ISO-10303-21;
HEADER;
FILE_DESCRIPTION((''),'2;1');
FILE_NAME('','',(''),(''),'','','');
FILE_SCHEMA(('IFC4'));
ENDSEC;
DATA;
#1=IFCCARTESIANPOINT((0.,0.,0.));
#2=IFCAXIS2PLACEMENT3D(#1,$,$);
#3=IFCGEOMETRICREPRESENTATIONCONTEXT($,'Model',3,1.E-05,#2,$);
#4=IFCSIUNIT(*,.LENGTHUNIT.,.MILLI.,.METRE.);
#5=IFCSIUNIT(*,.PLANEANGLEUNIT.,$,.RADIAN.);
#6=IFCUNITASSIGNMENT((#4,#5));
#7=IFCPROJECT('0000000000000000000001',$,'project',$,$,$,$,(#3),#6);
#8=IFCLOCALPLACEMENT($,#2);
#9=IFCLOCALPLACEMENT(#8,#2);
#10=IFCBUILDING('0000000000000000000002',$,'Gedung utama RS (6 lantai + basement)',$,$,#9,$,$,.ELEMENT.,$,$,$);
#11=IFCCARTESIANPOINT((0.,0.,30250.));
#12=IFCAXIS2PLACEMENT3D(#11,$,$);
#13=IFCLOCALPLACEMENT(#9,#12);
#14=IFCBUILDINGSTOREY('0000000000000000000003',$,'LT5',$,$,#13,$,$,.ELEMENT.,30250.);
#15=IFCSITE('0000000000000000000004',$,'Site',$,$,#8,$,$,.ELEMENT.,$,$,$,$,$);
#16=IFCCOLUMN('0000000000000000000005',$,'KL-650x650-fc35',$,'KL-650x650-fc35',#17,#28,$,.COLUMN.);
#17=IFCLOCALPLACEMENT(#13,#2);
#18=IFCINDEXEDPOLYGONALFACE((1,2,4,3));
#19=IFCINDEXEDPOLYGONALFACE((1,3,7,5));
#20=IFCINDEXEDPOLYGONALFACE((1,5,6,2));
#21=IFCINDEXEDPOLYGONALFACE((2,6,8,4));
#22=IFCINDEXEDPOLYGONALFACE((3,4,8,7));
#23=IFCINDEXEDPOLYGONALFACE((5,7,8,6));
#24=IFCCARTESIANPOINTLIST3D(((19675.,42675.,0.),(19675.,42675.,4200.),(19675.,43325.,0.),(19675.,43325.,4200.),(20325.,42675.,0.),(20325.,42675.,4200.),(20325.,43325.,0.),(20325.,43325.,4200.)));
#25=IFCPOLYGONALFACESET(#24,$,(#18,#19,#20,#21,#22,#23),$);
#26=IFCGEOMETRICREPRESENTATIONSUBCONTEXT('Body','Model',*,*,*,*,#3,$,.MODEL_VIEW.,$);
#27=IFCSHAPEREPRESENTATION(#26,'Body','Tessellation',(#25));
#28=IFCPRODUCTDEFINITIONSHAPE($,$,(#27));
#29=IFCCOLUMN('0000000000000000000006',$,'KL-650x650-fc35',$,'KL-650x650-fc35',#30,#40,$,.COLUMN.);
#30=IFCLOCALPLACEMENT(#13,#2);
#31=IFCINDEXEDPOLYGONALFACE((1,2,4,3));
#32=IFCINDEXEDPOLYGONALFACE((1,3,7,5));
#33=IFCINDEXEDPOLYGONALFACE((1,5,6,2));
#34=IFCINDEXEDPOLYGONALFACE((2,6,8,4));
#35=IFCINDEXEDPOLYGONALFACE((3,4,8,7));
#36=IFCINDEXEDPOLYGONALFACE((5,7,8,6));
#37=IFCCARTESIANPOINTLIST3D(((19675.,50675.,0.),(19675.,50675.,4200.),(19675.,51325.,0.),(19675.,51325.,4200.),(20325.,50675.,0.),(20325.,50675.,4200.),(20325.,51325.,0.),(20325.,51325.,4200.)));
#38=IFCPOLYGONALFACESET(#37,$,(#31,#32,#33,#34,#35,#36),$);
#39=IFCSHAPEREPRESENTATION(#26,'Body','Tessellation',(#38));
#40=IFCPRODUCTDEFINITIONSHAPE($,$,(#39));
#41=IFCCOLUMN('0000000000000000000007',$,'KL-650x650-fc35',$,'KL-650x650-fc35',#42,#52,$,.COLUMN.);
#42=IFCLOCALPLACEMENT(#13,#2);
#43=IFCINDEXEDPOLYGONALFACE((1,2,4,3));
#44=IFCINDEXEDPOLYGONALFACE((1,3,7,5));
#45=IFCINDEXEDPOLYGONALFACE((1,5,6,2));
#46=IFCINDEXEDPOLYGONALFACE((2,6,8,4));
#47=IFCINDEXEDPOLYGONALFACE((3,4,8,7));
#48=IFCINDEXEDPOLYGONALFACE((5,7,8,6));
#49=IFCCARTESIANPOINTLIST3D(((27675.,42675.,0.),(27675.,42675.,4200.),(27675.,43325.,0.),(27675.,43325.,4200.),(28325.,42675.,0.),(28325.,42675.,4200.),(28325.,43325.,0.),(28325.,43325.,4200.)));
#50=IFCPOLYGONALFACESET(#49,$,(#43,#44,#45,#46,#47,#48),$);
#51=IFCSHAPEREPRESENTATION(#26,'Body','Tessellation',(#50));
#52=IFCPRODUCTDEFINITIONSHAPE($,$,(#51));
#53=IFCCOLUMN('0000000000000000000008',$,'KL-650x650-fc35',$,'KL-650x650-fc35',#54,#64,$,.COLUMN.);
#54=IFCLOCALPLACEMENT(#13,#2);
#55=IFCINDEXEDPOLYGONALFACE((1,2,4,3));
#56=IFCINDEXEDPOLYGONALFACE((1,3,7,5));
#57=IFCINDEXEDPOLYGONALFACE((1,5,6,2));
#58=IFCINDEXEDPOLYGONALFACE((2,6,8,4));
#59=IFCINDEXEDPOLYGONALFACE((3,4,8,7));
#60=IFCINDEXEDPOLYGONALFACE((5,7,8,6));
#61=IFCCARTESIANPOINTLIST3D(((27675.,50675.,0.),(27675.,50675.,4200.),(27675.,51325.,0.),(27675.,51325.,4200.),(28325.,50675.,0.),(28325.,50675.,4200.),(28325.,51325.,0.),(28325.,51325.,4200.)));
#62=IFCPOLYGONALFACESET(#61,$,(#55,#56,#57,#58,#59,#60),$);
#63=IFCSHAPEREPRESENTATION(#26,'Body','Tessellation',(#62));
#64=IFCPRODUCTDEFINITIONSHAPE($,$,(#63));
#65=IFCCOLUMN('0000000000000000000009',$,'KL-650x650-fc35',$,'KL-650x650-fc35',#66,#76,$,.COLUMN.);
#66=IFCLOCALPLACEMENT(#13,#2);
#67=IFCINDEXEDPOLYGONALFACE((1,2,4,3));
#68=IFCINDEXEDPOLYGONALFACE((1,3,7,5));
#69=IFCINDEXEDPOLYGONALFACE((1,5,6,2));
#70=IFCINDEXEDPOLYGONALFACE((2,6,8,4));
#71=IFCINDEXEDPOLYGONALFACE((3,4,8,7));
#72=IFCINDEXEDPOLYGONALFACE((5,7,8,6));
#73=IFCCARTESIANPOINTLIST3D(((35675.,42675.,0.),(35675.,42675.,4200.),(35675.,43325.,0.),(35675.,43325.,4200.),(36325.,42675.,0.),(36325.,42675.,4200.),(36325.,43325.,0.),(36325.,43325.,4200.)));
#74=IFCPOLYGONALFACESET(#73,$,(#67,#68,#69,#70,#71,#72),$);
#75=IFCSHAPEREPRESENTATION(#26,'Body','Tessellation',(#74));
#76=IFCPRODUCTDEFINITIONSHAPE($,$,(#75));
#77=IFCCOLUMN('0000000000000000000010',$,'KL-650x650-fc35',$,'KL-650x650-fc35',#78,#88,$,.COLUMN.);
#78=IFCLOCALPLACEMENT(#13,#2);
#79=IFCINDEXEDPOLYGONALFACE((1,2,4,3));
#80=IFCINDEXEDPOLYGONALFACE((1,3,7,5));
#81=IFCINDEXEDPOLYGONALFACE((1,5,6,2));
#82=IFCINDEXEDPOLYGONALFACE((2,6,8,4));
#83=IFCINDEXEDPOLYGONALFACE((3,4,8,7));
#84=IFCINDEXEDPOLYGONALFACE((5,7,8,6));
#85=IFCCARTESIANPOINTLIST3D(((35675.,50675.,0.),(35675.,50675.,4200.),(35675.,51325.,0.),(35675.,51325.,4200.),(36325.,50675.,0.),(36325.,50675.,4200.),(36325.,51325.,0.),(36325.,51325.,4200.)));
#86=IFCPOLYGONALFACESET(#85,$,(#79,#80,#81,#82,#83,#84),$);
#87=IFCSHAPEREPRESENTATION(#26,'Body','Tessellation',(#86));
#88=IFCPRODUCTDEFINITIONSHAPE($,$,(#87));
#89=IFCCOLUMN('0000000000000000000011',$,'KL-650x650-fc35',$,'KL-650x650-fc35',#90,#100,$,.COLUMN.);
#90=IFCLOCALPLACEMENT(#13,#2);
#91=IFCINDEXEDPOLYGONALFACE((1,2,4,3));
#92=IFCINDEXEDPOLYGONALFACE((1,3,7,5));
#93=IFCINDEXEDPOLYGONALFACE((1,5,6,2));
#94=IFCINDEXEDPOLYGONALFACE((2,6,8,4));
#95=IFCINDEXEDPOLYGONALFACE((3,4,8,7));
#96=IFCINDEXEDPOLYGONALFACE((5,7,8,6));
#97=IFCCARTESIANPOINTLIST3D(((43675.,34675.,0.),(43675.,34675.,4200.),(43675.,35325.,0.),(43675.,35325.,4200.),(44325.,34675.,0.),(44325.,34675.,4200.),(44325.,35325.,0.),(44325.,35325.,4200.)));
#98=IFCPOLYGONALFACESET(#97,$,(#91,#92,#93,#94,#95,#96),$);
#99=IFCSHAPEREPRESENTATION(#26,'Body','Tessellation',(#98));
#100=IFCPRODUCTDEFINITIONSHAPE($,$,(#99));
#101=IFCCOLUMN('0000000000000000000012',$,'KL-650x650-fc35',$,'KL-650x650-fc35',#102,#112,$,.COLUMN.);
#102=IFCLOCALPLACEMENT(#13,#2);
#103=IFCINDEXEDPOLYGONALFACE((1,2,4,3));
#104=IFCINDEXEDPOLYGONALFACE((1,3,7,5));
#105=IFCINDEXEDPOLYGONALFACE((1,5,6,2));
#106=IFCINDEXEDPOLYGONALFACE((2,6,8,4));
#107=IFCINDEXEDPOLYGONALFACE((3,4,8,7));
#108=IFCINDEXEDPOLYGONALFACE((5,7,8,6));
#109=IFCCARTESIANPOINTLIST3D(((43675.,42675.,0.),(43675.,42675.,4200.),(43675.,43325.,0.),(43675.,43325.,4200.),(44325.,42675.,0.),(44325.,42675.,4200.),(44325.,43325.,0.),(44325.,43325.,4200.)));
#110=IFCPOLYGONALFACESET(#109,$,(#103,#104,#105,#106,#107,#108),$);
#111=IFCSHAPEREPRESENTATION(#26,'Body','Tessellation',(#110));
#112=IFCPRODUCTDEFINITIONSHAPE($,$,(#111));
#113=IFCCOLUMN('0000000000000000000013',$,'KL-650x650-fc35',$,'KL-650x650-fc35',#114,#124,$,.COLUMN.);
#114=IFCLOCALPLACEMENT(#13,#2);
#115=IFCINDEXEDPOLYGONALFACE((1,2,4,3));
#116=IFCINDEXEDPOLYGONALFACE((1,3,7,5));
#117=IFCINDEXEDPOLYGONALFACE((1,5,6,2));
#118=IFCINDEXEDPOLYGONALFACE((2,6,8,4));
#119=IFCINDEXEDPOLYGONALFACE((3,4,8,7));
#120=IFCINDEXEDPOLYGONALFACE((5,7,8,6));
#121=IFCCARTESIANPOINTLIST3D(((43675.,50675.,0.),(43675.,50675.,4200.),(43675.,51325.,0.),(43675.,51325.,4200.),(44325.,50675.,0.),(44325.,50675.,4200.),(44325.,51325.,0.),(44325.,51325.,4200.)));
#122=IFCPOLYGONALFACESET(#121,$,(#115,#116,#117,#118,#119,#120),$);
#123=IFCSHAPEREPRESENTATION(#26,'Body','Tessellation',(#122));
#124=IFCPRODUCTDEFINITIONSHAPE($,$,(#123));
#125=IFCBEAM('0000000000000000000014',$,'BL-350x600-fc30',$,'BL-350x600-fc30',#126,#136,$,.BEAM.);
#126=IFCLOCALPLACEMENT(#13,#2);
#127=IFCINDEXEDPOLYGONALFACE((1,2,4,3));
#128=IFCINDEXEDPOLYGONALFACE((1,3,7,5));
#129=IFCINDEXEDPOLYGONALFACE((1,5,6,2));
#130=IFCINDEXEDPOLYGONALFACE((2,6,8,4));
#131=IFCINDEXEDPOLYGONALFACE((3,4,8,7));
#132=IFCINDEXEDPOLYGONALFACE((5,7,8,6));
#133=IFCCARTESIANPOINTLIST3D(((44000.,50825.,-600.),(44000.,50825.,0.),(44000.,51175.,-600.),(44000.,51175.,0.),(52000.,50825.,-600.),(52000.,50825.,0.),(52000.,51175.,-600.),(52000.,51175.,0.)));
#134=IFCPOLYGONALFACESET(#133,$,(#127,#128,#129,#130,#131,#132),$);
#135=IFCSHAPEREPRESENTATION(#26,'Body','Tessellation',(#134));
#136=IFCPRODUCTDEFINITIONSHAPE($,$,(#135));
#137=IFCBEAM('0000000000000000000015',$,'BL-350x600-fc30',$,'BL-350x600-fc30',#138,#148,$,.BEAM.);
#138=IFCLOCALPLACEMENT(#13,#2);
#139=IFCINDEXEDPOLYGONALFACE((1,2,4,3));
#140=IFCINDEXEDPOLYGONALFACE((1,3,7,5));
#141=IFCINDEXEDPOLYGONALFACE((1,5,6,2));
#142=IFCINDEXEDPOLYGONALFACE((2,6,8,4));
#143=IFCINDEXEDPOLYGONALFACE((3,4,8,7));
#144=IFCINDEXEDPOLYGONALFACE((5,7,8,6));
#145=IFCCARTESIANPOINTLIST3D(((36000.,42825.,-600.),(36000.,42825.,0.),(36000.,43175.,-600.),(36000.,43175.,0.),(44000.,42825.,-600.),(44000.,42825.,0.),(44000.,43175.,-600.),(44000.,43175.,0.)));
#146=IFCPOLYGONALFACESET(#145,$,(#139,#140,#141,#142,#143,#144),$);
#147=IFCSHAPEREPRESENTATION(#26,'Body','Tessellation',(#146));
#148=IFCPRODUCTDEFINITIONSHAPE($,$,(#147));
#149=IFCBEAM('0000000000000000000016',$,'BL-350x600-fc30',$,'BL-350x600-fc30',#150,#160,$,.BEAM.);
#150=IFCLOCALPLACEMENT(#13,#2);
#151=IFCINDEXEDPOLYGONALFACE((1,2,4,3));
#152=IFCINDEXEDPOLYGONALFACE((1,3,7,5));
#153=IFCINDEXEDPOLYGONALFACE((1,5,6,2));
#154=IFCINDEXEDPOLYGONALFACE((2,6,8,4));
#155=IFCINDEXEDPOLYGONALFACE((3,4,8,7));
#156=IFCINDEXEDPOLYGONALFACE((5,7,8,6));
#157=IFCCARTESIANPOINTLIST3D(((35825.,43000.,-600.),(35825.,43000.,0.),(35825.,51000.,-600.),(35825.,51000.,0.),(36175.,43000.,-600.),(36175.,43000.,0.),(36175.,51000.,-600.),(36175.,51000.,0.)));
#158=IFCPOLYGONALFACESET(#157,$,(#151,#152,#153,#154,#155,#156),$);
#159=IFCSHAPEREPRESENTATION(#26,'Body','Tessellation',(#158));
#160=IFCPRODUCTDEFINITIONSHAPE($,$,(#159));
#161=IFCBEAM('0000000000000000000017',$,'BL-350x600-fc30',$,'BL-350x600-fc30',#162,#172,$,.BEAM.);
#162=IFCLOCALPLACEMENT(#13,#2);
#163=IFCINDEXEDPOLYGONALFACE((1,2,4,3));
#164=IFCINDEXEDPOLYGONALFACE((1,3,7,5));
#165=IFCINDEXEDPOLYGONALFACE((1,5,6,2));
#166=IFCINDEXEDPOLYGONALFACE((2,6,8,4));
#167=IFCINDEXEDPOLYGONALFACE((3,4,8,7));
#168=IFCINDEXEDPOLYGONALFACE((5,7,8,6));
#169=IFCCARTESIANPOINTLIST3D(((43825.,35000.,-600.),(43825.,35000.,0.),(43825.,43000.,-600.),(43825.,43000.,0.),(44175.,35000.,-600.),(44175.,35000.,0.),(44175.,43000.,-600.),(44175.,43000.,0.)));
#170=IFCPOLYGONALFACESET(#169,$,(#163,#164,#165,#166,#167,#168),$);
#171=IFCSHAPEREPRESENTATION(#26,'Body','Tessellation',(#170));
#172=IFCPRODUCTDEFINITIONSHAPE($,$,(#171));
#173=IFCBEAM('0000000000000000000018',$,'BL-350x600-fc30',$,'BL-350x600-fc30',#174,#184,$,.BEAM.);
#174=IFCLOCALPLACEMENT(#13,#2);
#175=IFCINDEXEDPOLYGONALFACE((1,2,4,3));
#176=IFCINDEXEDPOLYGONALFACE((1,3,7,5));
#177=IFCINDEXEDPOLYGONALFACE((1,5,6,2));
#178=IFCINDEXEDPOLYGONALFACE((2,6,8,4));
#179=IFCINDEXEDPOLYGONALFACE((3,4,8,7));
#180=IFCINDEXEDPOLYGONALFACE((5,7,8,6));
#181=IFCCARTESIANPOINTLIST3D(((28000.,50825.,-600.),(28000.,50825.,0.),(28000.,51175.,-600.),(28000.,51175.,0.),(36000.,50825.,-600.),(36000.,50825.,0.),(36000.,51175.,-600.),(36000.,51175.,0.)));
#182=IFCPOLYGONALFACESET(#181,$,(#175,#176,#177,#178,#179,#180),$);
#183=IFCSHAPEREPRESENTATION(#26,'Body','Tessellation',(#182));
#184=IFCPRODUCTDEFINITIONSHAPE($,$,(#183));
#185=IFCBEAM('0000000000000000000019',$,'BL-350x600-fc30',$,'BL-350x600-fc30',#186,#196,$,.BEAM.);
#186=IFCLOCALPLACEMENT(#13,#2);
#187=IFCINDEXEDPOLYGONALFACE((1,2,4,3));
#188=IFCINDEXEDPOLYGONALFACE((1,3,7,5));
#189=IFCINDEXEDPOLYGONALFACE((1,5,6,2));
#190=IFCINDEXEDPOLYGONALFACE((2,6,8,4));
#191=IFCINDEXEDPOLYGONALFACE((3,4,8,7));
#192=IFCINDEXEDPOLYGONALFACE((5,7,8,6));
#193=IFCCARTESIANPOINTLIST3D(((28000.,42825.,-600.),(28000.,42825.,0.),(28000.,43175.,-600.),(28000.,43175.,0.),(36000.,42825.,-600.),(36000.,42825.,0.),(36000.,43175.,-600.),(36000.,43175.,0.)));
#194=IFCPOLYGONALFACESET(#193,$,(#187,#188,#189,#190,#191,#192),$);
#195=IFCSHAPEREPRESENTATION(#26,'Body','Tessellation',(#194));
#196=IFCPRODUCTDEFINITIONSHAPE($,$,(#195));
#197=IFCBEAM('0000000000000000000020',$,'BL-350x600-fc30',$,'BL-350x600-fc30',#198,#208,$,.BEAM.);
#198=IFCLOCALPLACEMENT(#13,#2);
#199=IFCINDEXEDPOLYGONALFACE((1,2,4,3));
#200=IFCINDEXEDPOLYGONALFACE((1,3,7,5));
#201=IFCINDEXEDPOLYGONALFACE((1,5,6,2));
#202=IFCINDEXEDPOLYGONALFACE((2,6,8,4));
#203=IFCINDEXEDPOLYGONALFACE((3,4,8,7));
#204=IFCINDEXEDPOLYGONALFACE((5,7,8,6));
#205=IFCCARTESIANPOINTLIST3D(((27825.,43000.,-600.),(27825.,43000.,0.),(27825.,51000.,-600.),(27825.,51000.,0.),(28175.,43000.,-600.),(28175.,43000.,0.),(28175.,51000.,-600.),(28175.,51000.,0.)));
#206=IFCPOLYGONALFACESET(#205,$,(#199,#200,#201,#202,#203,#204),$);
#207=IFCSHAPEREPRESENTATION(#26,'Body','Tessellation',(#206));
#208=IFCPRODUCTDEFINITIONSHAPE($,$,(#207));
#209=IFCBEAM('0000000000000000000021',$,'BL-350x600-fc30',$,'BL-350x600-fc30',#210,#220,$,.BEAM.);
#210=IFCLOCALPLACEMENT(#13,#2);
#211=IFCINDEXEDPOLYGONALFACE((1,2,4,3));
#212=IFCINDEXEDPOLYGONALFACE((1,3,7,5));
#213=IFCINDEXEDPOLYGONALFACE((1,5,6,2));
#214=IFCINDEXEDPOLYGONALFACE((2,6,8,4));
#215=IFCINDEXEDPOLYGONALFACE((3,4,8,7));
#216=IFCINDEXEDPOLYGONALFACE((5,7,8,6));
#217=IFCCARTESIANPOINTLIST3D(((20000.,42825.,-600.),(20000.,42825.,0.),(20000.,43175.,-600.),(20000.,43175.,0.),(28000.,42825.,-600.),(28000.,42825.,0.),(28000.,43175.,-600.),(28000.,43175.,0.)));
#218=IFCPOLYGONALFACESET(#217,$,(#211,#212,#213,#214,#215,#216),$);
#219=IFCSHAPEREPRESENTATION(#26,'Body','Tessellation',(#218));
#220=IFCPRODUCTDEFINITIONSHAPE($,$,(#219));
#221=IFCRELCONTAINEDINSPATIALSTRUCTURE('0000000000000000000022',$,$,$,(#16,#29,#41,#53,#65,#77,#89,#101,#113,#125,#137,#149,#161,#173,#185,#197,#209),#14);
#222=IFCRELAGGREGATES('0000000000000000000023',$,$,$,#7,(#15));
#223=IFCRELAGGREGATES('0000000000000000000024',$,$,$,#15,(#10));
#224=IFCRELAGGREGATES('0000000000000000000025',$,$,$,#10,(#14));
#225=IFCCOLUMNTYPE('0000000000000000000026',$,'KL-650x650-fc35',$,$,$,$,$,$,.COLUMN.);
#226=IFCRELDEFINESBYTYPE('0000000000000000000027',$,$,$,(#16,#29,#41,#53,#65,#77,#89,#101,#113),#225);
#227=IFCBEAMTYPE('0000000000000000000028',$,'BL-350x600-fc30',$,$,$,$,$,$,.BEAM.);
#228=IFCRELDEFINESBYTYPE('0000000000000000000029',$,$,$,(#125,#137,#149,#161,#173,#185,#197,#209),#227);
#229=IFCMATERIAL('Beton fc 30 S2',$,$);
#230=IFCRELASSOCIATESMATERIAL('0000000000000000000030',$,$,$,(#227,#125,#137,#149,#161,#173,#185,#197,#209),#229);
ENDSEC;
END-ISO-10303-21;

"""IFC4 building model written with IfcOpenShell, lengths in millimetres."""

from ifc_helpers import new_model, si_unit, frame, origin, origin_2d, place, context, subcontext, project, spatial, rectangle, extrude, material, material_profile, profile_set, profile_usage, type_object, element, save


model = new_model("IFC4")

# Units and contexts
model_context = context("Model", 3, precision=1e-05, world=origin())
body_context = subcontext(model_context, "Body", "Model", "MODEL_VIEW")
ifc_project = project(units=[si_unit("LENGTHUNIT", "METRE", prefix="MILLI"), si_unit("PLANEANGLEUNIT", "RADIAN")], contexts=[model_context])

# Site, building, storey
site_placement = place(None, origin())
site = spatial("IfcSite", under=ifc_project, at=site_placement, Name="Site", CompositionType="ELEMENT")
building_placement = place(site_placement, origin())
building = spatial("IfcBuilding", under=site, at=building_placement, Name="Gedung utama RS (6 lantai + basement)", CompositionType="ELEMENT")
storey_placement = place(building_placement, frame((0.0, 0.0, 30250.0)))
storey = spatial("IfcBuildingStorey", under=building, at=storey_placement, Name="LT5", CompositionType="ELEMENT", Elevation=30250.0)

# Columns
ifc_material_profile_1 = material_profile(None, rectangle(XDim=650.0, YDim=650.0, at=origin_2d()), Name="KL-650x650-fc35")
ifc_profile_set_1 = profile_set([ifc_material_profile_1], Name="KL-650x650-fc35")
ifc_profile_usage_1 = profile_usage(ifc_profile_set_1, cardinal=5)
column_type = type_object("IfcColumnType", Name="KL-650x650-fc35", PredefinedType="COLUMN", material=ifc_profile_set_1)
for number, where, z_axis, x_axis, name in (
    (1, (20000.0, 43000.0, 0.0), (0.0, 0.0, 1.0), (1.0, 0.0, 0.0), "KL-650x650-fc35"),
    (2, (20000.0, 51000.0, 0.0), (0.0, 0.0, 1.0), (1.0, 0.0, 0.0), "KL-650x650-fc35"),
    (3, (28000.0, 43000.0, 0.0), (0.0, 0.0, 1.0), (1.0, 0.0, 0.0), "KL-650x650-fc35"),
    (4, (28000.0, 51000.0, 0.0), (0.0, 0.0, 1.0), (1.0, 0.0, 0.0), "KL-650x650-fc35"),
    (5, (36000.0, 43000.0, 0.0), (0.0, 0.0, 1.0), (1.0, 0.0, 0.0), "KL-650x650-fc35"),
    (6, (36000.0, 51000.0, 0.0), (0.0, 0.0, 1.0), (1.0, 0.0, 0.0), "KL-650x650-fc35"),
    (7, (44000.0, 35000.0, 0.0), (0.0, 0.0, 1.0), (1.0, 0.0, 0.0), "KL-650x650-fc35"),
    (8, (44000.0, 43000.0, 0.0), (0.0, 0.0, 1.0), (1.0, 0.0, 0.0), "KL-650x650-fc35"),
    (9, (44000.0, 51000.0, 0.0), (0.0, 0.0, 1.0), (1.0, 0.0, 0.0), "KL-650x650-fc35"),
):
    element("IfcColumn", number, at=place(storey_placement, frame(where, z_axis=z_axis, x_axis=x_axis)), inside=storey, type_object=column_type, material=ifc_profile_usage_1, Name=name, ObjectType="KL-650x650-fc35", PredefinedType="COLUMN", context=body_context, shape_type="SweptSolid", body=[
        extrude(rectangle(XDim=650.0, YDim=650.0, at=origin_2d()), origin(), (0.0, 0.0, 1.0), 4200.0),
    ])

# Beams
ifc_material_1 = material(Name="Beton fc 30 S2")
ifc_material_profile_2 = material_profile(ifc_material_1, rectangle(XDim=350.0, YDim=600.0, at=origin_2d()), Name="BL-350x600-fc30")
ifc_profile_set_2 = profile_set([ifc_material_profile_2], Name="BL-350x600-fc30")
ifc_profile_usage_2 = profile_usage(ifc_profile_set_2, cardinal=8)
beam_type = type_object("IfcBeamType", Name="BL-350x600-fc30", PredefinedType="BEAM", material=ifc_profile_set_2)
for number, where, name in (
    (10, (44000.0, 51000.0, -300.0), "BL-350x600-fc30"),
    (11, (36000.0, 43000.0, -300.0), "BL-350x600-fc30"),
):
    element("IfcBeam", number, at=place(storey_placement, frame(where)), inside=storey, type_object=beam_type, material=ifc_profile_usage_2, Name=name, ObjectType="BL-350x600-fc30", PredefinedType="BEAM", context=body_context, shape_type="SweptSolid", body=[
        extrude(rectangle(XDim=350.0, YDim=600.0, at=origin_2d()), frame((0.0, 0.0, 0.0), z_axis=(1.0, 0.0, 0.0), x_axis=(0.0, 1.0, 0.0)), (0.0, 0.0, 1.0), 8000.0),
    ])
for number, where, name in (
    (12, (36000.0, 43000.0, -300.0), "BL-350x600-fc30"),
    (13, (44000.0, 35000.0, -300.0), "BL-350x600-fc30"),
):
    element("IfcBeam", number, at=place(storey_placement, frame(where)), inside=storey, type_object=beam_type, material=ifc_profile_usage_2, Name=name, ObjectType="BL-350x600-fc30", PredefinedType="BEAM", context=body_context, shape_type="SweptSolid", body=[
        extrude(rectangle(XDim=350.0, YDim=600.0, at=origin_2d()), frame((0.0, 0.0, 0.0), z_axis=(0.0, 1.0, 0.0), x_axis=(-1.0, 0.0, 0.0)), (0.0, 0.0, 1.0), 8000.0),
    ])
for number, where, name in (
    (14, (28000.0, 51000.0, -300.0), "BL-350x600-fc30"),
    (15, (28000.0, 43000.0, -300.0), "BL-350x600-fc30"),
):
    element("IfcBeam", number, at=place(storey_placement, frame(where)), inside=storey, type_object=beam_type, material=ifc_profile_usage_2, Name=name, ObjectType="BL-350x600-fc30", PredefinedType="BEAM", context=body_context, shape_type="SweptSolid", body=[
        extrude(rectangle(XDim=350.0, YDim=600.0, at=origin_2d()), frame((0.0, 0.0, 0.0), z_axis=(1.0, 0.0, 0.0), x_axis=(0.0, 1.0, 0.0)), (0.0, 0.0, 1.0), 8000.0),
    ])
beam_1_placement = place(storey_placement, frame((28000.0, 43000.0, -300.0)))
element("IfcBeam", 16, at=beam_1_placement, inside=storey, type_object=beam_type, material=ifc_profile_usage_2, Name="BL-350x600-fc30", ObjectType="BL-350x600-fc30", PredefinedType="BEAM", context=body_context, shape_type="SweptSolid", body=[
    extrude(rectangle(XDim=350.0, YDim=600.0, at=origin_2d()), frame((0.0, 0.0, 0.0), z_axis=(0.0, 1.0, 0.0), x_axis=(-1.0, 0.0, 0.0)), (0.0, 0.0, 1.0), 8000.0),
])
beam_2_placement = place(storey_placement, frame((20000.0, 43000.0, -300.0)))
element("IfcBeam", 17, at=beam_2_placement, inside=storey, type_object=beam_type, material=ifc_profile_usage_2, Name="BL-350x600-fc30", ObjectType="BL-350x600-fc30", PredefinedType="BEAM", context=body_context, shape_type="SweptSolid", body=[
    extrude(rectangle(XDim=350.0, YDim=600.0, at=origin_2d()), frame((0.0, 0.0, 0.0), z_axis=(1.0, 0.0, 0.0), x_axis=(0.0, 1.0, 0.0)), (0.0, 0.0, 1.0), 8000.0),
])

save(model, "model.ifc")
